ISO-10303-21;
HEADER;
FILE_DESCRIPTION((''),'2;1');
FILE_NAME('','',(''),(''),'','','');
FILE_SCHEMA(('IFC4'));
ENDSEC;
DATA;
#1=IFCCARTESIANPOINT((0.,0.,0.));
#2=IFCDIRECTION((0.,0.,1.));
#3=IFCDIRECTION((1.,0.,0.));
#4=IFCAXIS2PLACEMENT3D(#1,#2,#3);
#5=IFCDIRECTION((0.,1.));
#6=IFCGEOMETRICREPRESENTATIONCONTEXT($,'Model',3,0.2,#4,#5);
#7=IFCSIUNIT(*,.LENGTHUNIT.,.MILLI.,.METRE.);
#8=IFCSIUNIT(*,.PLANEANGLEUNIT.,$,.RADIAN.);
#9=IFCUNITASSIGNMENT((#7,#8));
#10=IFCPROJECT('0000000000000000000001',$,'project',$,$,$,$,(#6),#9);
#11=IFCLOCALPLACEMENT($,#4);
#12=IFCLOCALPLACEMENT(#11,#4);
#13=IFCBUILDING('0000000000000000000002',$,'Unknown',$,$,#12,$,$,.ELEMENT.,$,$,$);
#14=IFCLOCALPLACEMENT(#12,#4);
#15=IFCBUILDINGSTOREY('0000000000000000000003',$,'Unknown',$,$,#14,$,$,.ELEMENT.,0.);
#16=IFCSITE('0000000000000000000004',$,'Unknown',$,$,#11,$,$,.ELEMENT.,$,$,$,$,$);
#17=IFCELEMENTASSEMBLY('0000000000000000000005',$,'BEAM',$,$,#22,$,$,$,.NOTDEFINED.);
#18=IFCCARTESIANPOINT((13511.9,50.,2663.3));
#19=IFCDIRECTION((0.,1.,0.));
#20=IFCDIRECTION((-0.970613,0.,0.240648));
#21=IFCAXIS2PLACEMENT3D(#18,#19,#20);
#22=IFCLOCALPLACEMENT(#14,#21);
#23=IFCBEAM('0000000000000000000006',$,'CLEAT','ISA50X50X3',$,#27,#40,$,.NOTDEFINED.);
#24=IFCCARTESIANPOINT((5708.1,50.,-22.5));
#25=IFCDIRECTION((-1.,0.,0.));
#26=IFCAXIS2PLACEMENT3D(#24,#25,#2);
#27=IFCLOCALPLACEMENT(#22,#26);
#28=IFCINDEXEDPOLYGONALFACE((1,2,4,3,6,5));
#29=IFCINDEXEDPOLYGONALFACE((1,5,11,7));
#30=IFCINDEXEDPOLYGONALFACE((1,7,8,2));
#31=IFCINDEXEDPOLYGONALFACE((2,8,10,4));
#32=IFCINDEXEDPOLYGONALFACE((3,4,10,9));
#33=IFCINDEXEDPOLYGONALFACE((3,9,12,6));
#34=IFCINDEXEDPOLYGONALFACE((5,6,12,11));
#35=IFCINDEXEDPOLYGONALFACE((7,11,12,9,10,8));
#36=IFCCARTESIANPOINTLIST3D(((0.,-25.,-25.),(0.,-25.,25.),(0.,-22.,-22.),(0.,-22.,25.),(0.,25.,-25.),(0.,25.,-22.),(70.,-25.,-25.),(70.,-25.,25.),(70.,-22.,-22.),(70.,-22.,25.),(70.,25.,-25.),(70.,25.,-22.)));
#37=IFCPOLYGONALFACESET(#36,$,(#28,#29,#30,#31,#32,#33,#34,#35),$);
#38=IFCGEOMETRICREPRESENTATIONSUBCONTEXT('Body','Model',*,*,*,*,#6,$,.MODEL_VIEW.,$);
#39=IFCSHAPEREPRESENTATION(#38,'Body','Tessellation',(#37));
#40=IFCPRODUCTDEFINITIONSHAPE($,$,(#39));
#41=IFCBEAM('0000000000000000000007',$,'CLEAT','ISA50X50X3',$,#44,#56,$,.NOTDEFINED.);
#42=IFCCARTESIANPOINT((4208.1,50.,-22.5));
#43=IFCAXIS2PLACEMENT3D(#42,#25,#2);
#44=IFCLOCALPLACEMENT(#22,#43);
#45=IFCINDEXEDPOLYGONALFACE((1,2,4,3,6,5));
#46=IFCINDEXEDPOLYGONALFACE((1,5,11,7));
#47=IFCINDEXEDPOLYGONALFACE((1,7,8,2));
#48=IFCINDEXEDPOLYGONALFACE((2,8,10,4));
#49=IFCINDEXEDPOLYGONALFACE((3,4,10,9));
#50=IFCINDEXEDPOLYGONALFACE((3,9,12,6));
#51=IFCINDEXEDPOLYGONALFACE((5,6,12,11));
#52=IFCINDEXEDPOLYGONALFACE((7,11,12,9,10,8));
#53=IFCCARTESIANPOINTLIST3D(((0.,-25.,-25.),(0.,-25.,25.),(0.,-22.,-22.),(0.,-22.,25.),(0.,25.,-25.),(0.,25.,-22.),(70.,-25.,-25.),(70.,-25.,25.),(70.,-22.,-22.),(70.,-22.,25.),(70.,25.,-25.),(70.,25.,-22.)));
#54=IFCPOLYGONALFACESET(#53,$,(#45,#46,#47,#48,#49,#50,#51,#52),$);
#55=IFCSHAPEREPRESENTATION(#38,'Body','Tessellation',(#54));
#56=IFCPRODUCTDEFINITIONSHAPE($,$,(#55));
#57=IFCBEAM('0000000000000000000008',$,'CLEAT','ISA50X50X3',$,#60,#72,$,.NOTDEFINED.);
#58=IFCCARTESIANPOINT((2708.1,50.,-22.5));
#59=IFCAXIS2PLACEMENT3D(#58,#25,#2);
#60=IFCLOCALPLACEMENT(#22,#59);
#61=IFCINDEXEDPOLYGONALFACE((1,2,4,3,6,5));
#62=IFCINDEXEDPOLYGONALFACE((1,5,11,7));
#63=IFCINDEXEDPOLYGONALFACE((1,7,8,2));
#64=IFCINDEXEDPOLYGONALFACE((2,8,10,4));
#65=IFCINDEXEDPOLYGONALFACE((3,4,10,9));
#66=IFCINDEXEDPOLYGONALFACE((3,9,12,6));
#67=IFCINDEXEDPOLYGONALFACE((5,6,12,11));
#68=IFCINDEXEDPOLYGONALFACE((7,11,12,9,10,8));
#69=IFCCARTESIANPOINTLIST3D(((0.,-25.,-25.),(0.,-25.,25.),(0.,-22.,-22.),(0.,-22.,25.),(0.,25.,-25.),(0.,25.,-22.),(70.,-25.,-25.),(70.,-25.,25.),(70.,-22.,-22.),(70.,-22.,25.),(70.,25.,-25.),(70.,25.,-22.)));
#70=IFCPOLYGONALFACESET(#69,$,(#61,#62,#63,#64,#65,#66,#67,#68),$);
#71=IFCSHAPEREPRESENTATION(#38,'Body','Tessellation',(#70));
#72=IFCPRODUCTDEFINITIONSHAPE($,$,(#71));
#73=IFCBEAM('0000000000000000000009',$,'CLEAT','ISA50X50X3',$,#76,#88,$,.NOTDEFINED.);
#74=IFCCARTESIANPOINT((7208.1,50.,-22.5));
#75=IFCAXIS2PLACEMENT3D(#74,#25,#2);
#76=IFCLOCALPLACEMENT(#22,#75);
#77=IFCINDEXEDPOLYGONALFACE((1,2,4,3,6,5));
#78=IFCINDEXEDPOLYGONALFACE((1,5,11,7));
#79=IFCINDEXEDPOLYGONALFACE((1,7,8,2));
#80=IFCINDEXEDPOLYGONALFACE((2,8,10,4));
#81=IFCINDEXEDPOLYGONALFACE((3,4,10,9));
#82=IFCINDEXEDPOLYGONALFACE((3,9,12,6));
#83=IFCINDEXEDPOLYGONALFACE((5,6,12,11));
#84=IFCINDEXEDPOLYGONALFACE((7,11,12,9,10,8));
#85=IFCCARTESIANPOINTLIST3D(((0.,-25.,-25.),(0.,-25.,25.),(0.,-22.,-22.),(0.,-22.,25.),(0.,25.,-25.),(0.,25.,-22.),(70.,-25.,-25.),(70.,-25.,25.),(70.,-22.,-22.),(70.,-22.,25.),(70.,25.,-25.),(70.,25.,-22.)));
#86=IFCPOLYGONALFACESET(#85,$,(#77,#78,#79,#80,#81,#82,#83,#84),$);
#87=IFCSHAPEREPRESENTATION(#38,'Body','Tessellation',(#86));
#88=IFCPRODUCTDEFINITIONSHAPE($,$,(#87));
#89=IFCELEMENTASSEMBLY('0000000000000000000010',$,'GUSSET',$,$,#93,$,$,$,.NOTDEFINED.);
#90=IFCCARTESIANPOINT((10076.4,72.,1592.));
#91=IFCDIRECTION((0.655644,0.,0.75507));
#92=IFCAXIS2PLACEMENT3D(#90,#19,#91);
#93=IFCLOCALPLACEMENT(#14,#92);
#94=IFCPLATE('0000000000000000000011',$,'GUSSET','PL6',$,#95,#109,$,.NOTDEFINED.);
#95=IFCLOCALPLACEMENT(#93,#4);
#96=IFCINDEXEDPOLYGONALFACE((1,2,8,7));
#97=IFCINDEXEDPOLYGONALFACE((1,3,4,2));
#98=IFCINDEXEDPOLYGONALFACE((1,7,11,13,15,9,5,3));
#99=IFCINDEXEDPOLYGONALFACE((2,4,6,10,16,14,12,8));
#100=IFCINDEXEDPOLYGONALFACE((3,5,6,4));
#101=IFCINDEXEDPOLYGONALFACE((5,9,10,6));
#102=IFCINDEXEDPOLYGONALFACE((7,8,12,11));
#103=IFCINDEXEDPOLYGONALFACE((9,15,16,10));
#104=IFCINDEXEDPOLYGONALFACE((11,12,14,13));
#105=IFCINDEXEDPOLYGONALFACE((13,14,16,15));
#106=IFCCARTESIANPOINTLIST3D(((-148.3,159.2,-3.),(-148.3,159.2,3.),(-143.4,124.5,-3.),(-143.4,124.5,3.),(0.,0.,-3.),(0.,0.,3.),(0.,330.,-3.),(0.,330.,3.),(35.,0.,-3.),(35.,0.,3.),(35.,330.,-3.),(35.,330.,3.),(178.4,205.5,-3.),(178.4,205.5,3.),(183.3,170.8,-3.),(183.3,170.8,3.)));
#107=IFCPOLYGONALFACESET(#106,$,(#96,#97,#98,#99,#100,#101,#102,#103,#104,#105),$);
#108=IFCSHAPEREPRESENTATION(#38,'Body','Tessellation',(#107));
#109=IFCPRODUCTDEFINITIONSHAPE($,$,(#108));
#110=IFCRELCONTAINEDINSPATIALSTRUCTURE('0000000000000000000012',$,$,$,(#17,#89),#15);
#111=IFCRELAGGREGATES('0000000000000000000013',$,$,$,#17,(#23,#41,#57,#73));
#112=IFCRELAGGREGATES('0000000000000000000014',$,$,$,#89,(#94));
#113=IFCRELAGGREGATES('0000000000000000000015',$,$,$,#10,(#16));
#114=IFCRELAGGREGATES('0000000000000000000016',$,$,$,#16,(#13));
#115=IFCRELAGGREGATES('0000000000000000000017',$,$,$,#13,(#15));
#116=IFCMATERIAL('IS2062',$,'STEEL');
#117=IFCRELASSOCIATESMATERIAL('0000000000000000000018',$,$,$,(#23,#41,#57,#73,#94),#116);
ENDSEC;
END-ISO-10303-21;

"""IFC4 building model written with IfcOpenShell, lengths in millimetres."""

from ifc_helpers import new_model, si_unit, direction, frame, origin_with_axes, place, context, subcontext, project, spatial, line, indexed_curve, outline, extrude, material, element, aggregate, save


model = new_model("IFC4")

# Units and contexts
model_context = context("Model", 3, precision=0.2, world=origin_with_axes(), true_north=direction((0.0, 1.0)))
body_context = subcontext(model_context, "Body", "Model", "MODEL_VIEW")
ifc_project = project(units=[si_unit("LENGTHUNIT", "METRE", prefix="MILLI"), si_unit("PLANEANGLEUNIT", "RADIAN")], contexts=[model_context])

# Site, building, storey
site_placement = place(None, origin_with_axes())
site = spatial("IfcSite", under=ifc_project, at=site_placement, Name="Unknown", CompositionType="ELEMENT")
building_placement = place(site_placement, origin_with_axes())
building = spatial("IfcBuilding", under=site, at=building_placement, Name="Unknown", CompositionType="ELEMENT")
storey_placement = place(building_placement, origin_with_axes())
storey = spatial("IfcBuildingStorey", under=building, at=storey_placement, Name="Unknown", CompositionType="ELEMENT", Elevation=0.0)

# Shared definitions
ifc_material_1 = material(Name="IS2062", Category="STEEL")

# Element assembly, beams
assembly_1_placement = place(storey_placement, frame((13511.9, 50.0, 2663.3), z_axis=(0.0, 1.0, 0.0), x_axis=(-0.970613, 0.0, 0.240648)))
assembly_1 = element("IfcElementAssembly", 1, at=assembly_1_placement, inside=storey, Name="BEAM", PredefinedType="NOTDEFINED")
beam_1_placement = place(assembly_1_placement, frame((5708.1, 50.0, -22.5), z_axis=(-1.0, 0.0, 0.0), x_axis=(0.0, 0.0, 1.0)))
beam_1 = element("IfcBeam", 2, at=beam_1_placement, material=ifc_material_1, Name="CLEAT", Description="ISA50X50X3", PredefinedType="NOTDEFINED", context=body_context, shape_type="SolidModel", body=[
    extrude(outline(indexed_curve([(-25.0, -25.0), (25.0, -25.0), (25.0, -22.0), (-22.0, -22.0), (-22.0, 25.0), (-25.0, 25.0)], segments=[line(1, 2, 3, 4, 5, 6, 1)])), frame((0.0, 0.0, 0.0), z_axis=(-1.0, 0.0, 0.0), x_axis=(0.0, 0.0, 1.0)), (0.0, 0.0, -1.0), 70.0),
])
beam_2_placement = place(assembly_1_placement, frame((4208.1, 50.0, -22.5), z_axis=(-1.0, 0.0, 0.0), x_axis=(0.0, 0.0, 1.0)))
beam_2 = element("IfcBeam", 3, at=beam_2_placement, material=ifc_material_1, Name="CLEAT", Description="ISA50X50X3", PredefinedType="NOTDEFINED", context=body_context, shape_type="SolidModel", body=[
    extrude(outline(indexed_curve([(-25.0, -25.0), (25.0, -25.0), (25.0, -22.0), (-22.0, -22.0), (-22.0, 25.0), (-25.0, 25.0)], segments=[line(1, 2, 3, 4, 5, 6, 1)])), frame((0.0, 0.0, 0.0), z_axis=(-1.0, 0.0, 0.0), x_axis=(0.0, 0.0, 1.0)), (0.0, 0.0, -1.0), 70.0),
])
beam_3_placement = place(assembly_1_placement, frame((2708.1, 50.0, -22.5), z_axis=(-1.0, 0.0, 0.0), x_axis=(0.0, 0.0, 1.0)))
beam_3 = element("IfcBeam", 4, at=beam_3_placement, material=ifc_material_1, Name="CLEAT", Description="ISA50X50X3", PredefinedType="NOTDEFINED", context=body_context, shape_type="SolidModel", body=[
    extrude(outline(indexed_curve([(-25.0, -25.0), (25.0, -25.0), (25.0, -22.0), (-22.0, -22.0), (-22.0, 25.0), (-25.0, 25.0)], segments=[line(1, 2, 3, 4, 5, 6, 1)])), frame((0.0, 0.0, 0.0), z_axis=(-1.0, 0.0, 0.0), x_axis=(0.0, 0.0, 1.0)), (0.0, 0.0, -1.0), 70.0),
])
beam_4_placement = place(assembly_1_placement, frame((7208.1, 50.0, -22.5), z_axis=(-1.0, 0.0, 0.0), x_axis=(0.0, 0.0, 1.0)))
beam_4 = element("IfcBeam", 5, at=beam_4_placement, material=ifc_material_1, Name="CLEAT", Description="ISA50X50X3", PredefinedType="NOTDEFINED", context=body_context, shape_type="SolidModel", body=[
    extrude(outline(indexed_curve([(-25.0, -25.0), (25.0, -25.0), (25.0, -22.0), (-22.0, -22.0), (-22.0, 25.0), (-25.0, 25.0)], segments=[line(1, 2, 3, 4, 5, 6, 1)])), frame((0.0, 0.0, 0.0), z_axis=(-1.0, 0.0, 0.0), x_axis=(0.0, 0.0, 1.0)), (0.0, 0.0, -1.0), 70.0),
])
aggregate(assembly_1, [beam_1, beam_2, beam_3, beam_4])

# Element assembly, plate
assembly_2_placement = place(storey_placement, frame((10076.4, 72.0, 1592.0), z_axis=(0.0, 1.0, 0.0), x_axis=(0.655644, 0.0, 0.75507)))
assembly_2 = element("IfcElementAssembly", 6, at=assembly_2_placement, inside=storey, Name="GUSSET", PredefinedType="NOTDEFINED")
plate_placement = place(assembly_2_placement, origin_with_axes())
plate = element("IfcPlate", 7, at=plate_placement, material=ifc_material_1, Name="GUSSET", Description="PL6", PredefinedType="NOTDEFINED", context=body_context, shape_type="SolidModel", body=[
    extrude(outline(indexed_curve([(0.0, 0.0), (35.0, 0.0), (183.3, 170.8), (178.4, 205.5), (35.0, 330.0), (0.0, 330.0), (-148.3, 159.2), (-143.4, 124.5)], segments=[line(1, 2, 3, 4, 5, 6, 7, 8, 1)])), frame((0.0, 0.0, 3.0), z_axis=(0.0, 0.0, 1.0), x_axis=(1.0, 0.0, 0.0)), (0.0, 0.0, -1.0), 6.0),
])
aggregate(assembly_2, [plate])

save(model, "model.ifc")
